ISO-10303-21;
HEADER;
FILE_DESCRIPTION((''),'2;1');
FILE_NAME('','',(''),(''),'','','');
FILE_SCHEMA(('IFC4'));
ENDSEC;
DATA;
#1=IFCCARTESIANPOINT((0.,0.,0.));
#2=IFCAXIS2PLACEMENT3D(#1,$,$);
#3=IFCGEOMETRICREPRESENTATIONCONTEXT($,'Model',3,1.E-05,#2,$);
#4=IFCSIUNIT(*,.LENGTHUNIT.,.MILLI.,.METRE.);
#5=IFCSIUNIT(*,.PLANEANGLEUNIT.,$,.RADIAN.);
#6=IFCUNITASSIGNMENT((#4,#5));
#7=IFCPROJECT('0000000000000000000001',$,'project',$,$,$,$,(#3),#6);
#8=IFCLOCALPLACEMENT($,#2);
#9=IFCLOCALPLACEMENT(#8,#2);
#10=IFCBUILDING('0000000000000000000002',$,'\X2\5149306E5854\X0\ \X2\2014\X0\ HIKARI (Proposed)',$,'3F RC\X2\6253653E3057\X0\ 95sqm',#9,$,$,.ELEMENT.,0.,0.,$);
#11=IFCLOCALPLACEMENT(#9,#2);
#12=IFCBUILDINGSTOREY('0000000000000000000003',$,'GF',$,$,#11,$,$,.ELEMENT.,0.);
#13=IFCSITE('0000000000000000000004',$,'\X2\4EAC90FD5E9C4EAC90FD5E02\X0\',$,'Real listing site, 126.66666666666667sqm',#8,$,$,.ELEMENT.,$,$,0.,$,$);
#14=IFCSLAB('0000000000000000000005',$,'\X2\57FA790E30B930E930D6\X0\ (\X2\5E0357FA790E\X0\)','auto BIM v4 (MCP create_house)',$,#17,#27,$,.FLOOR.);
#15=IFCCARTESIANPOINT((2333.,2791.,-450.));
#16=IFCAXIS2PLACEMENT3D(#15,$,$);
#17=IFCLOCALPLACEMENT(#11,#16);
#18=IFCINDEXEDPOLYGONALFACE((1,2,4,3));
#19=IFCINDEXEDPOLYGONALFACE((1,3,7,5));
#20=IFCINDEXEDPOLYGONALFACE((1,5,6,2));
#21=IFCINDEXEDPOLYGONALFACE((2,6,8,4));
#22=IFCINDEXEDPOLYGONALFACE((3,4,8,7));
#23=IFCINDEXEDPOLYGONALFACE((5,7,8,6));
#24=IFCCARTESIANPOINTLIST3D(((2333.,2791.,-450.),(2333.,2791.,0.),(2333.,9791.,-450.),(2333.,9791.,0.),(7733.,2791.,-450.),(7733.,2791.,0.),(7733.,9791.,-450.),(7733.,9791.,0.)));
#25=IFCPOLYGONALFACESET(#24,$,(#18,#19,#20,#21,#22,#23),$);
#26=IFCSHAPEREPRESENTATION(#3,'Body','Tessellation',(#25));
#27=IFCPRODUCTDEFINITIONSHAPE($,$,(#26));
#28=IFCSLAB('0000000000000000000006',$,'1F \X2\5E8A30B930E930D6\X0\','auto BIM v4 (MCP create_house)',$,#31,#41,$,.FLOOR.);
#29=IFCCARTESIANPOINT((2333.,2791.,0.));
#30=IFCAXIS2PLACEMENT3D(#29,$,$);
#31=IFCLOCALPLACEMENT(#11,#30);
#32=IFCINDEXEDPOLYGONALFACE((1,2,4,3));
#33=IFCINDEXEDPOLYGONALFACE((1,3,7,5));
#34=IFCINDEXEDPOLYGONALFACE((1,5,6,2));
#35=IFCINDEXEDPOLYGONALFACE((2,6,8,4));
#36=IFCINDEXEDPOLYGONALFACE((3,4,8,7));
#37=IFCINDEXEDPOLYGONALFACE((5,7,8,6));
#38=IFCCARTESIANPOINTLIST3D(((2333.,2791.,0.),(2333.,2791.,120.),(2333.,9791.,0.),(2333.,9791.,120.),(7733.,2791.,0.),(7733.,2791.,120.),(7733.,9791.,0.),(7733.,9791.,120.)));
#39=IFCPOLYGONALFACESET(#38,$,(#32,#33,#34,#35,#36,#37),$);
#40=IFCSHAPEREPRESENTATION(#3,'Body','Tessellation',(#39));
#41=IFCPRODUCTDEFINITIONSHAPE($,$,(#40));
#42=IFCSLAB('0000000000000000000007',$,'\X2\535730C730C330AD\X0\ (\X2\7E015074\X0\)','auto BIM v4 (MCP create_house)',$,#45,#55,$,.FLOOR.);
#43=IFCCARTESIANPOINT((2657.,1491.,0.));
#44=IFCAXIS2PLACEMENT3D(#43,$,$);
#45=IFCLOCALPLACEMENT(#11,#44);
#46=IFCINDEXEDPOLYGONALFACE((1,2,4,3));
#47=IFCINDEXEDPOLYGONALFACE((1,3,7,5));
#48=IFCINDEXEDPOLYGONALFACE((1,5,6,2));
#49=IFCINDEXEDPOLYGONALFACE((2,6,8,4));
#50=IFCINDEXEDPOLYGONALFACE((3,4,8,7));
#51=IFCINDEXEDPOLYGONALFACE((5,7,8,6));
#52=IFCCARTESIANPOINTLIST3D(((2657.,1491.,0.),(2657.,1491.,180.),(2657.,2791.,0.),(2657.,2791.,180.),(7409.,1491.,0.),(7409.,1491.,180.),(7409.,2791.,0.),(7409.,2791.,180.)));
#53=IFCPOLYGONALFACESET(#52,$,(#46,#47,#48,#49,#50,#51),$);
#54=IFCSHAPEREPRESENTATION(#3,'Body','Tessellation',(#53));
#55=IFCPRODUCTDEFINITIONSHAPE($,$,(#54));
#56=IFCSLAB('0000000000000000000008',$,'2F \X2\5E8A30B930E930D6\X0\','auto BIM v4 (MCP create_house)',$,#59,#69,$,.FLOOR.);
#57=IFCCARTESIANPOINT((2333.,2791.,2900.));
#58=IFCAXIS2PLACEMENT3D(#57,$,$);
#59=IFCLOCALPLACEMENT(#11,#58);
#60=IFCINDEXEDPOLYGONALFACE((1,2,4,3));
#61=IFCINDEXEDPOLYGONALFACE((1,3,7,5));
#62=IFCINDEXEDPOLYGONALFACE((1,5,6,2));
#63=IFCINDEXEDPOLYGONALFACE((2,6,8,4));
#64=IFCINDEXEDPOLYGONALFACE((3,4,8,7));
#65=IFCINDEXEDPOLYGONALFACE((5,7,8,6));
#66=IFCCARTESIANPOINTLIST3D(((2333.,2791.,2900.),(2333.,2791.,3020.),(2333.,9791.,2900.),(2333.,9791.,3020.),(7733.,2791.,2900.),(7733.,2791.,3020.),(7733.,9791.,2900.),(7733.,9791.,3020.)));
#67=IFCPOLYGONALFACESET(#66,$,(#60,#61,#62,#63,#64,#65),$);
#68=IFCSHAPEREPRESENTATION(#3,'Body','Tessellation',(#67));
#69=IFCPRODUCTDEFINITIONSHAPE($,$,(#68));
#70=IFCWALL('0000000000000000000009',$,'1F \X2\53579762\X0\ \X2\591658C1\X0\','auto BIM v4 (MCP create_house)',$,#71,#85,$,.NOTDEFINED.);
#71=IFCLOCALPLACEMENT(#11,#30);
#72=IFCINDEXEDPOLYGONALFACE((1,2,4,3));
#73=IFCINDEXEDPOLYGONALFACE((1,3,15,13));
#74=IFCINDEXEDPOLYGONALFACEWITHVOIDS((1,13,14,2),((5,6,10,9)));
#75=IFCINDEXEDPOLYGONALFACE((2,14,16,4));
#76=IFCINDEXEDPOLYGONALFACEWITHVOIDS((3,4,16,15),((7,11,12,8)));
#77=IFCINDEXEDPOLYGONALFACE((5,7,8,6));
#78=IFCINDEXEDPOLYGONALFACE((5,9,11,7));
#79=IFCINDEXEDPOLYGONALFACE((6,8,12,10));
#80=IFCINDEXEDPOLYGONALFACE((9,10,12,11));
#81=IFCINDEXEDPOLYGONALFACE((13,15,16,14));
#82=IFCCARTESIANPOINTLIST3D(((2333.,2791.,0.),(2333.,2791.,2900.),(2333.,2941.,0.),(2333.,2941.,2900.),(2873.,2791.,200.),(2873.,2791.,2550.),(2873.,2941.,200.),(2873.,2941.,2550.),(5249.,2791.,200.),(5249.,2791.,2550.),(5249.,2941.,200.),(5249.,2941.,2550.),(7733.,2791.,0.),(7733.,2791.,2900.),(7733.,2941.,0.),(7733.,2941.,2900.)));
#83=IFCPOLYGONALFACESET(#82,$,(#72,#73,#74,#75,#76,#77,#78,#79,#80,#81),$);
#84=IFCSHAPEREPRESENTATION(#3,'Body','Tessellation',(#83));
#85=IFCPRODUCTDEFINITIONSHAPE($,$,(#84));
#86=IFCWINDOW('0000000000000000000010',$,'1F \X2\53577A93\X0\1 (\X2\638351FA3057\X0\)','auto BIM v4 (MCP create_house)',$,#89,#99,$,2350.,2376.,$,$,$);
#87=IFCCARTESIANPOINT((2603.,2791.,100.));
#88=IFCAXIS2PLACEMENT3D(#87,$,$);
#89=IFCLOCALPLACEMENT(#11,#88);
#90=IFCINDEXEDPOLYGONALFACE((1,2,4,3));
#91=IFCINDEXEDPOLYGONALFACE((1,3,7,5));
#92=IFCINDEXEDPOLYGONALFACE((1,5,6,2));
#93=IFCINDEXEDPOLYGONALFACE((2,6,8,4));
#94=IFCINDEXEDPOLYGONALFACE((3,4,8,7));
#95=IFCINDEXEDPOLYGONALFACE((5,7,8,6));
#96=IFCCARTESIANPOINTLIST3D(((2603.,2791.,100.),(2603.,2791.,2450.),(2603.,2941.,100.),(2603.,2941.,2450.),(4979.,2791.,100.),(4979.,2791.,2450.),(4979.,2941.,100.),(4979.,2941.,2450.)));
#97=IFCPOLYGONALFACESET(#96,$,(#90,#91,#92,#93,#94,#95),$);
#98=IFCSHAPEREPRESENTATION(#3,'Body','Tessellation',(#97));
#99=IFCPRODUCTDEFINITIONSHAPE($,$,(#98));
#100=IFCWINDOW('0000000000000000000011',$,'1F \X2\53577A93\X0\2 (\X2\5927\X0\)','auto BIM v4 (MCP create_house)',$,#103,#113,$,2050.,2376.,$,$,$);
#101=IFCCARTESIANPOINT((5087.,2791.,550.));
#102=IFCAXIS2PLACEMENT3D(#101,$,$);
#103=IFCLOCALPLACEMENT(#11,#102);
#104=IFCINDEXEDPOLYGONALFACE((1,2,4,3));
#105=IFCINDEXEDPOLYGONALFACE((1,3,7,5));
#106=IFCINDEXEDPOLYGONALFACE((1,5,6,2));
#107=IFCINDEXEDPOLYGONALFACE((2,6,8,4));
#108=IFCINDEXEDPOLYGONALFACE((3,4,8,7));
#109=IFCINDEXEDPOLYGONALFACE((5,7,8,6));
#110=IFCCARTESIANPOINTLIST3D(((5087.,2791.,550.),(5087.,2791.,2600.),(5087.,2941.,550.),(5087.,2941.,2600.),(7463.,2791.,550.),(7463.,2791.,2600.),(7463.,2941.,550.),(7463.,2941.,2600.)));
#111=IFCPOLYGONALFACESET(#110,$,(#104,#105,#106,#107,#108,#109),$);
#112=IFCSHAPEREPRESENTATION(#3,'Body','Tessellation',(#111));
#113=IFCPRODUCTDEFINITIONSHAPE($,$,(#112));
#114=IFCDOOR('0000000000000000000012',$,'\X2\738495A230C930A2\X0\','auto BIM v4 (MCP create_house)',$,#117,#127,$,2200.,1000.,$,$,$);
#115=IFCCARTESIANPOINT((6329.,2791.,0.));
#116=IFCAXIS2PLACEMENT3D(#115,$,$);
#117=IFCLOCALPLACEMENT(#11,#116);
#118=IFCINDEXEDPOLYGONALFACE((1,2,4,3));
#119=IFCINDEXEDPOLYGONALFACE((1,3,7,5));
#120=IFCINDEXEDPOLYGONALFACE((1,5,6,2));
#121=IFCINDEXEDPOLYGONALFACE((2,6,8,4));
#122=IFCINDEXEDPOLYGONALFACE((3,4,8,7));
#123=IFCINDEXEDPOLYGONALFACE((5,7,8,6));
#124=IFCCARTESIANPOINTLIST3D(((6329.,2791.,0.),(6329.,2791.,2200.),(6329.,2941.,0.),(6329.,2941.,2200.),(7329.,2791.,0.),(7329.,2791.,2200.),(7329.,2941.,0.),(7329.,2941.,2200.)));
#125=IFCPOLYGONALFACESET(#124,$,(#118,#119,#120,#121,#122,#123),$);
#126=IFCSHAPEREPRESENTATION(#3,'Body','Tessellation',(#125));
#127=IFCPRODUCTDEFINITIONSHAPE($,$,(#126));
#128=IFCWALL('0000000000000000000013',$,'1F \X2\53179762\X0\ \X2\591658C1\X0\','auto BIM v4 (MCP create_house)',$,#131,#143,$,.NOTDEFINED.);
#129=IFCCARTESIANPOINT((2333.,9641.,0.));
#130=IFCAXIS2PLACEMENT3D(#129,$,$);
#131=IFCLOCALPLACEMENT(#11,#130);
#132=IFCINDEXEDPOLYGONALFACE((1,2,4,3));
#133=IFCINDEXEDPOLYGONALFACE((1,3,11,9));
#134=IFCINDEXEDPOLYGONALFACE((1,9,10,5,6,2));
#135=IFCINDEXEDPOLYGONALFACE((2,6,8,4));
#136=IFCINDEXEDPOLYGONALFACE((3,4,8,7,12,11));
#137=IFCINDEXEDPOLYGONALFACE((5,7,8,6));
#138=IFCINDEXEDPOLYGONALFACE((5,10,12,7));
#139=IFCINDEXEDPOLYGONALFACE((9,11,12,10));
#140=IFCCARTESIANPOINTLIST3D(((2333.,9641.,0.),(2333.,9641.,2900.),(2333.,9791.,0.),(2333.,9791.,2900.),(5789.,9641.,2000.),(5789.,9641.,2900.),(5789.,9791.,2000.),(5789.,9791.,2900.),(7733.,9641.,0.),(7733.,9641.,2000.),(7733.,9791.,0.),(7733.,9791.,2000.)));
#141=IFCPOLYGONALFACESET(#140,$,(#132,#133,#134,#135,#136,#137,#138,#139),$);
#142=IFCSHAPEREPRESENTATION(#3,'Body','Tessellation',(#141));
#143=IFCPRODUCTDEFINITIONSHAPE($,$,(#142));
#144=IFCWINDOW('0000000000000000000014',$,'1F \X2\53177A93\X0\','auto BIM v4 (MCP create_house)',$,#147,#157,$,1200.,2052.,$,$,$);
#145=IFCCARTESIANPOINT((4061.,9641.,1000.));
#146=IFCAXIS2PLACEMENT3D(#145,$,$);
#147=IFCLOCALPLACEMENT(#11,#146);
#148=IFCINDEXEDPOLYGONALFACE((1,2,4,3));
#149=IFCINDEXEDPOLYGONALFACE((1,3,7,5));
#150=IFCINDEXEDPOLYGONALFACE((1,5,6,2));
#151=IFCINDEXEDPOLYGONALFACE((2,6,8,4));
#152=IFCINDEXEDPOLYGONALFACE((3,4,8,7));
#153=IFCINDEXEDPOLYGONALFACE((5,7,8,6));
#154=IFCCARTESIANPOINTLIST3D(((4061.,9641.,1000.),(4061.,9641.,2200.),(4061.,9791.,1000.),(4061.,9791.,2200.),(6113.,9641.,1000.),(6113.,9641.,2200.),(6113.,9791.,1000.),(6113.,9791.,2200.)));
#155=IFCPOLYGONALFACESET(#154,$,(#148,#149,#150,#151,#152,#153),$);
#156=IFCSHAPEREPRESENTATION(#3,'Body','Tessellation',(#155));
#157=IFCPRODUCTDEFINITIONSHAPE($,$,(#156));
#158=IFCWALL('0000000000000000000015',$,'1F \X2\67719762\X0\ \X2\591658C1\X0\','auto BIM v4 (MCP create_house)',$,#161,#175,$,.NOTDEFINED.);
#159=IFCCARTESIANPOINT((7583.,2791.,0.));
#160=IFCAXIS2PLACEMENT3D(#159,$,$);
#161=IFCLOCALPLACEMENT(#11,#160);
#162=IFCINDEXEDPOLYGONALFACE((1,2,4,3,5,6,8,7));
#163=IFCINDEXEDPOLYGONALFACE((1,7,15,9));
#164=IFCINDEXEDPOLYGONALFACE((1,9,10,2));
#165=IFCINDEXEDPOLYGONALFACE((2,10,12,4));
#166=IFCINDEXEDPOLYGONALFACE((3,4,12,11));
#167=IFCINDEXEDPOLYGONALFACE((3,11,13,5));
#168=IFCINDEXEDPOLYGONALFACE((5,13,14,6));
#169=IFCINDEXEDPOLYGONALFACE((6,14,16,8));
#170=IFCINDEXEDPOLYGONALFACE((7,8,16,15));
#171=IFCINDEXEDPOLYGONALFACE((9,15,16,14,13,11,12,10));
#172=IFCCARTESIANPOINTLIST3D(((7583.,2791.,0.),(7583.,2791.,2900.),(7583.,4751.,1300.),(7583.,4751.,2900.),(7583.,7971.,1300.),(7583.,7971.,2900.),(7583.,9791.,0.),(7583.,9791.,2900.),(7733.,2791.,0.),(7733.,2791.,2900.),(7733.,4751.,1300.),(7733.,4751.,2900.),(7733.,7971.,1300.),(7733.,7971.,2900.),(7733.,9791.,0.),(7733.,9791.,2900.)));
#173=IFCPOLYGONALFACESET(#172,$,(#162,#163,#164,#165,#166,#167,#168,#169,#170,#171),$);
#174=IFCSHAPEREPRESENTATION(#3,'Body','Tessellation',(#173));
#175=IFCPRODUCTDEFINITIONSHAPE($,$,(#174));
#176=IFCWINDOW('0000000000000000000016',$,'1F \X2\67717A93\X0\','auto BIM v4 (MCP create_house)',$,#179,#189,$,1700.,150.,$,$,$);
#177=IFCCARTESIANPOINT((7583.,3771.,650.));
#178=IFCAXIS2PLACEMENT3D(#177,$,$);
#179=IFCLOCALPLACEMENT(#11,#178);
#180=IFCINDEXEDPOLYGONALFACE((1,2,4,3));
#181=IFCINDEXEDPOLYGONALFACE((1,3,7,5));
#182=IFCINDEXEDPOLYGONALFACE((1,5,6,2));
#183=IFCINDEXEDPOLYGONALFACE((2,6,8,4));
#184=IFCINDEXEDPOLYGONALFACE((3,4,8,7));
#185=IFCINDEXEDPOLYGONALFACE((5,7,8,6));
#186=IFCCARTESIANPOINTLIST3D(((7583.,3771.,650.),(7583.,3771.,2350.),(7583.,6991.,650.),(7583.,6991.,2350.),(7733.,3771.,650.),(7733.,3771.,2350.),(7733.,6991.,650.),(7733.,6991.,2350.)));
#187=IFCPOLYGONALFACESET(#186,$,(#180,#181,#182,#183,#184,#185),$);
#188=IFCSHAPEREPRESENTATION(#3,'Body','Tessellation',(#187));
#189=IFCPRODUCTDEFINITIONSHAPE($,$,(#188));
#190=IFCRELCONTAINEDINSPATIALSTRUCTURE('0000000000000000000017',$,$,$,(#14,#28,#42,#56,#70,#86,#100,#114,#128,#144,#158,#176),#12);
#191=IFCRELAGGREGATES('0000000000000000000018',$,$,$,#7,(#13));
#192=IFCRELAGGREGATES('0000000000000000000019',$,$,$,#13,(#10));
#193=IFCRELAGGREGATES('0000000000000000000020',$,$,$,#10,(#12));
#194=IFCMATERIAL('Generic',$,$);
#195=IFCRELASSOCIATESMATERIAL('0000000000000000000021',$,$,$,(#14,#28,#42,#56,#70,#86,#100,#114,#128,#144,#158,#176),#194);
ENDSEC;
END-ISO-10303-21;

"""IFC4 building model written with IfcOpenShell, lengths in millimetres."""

from ifc_helpers import new_model, si_unit, frame, frame_2d, origin, place, context, project, spatial, rectangle, extrude, material, element, fill, save


model = new_model("IFC4")

# Units and contexts
model_context = context("Model", 3, precision=1e-05, world=origin())
ifc_project = project(units=[si_unit("LENGTHUNIT", "METRE", prefix="MILLI"), si_unit("PLANEANGLEUNIT", "RADIAN")], contexts=[model_context])

# Site, building, storey
site_placement = place(None, origin())
site = spatial("IfcSite", under=ifc_project, at=site_placement, Name="京都府京都市", ObjectType="Real listing site, 126.66666666666667sqm", CompositionType="ELEMENT", RefElevation=0.0)
building_placement = place(site_placement, origin())
building = spatial("IfcBuilding", under=site, at=building_placement, Name="光の塔 — HIKARI (Proposed)", ObjectType="3F RC打放し 95sqm", CompositionType="ELEMENT", ElevationOfRefHeight=0.0, ElevationOfTerrain=0.0)
storey_placement = place(building_placement, origin())
storey = spatial("IfcBuildingStorey", under=building, at=storey_placement, Name="GF", CompositionType="ELEMENT", Elevation=0.0)

# Slabs
ifc_material = material(Name="Generic")
slab_1_placement = place(storey_placement, frame((2333.0, 2791.0, -450.0)))
element("IfcSlab", 1, at=slab_1_placement, inside=storey, material=ifc_material, Name="基礎スラブ (布基礎)", Description="auto BIM v4 (MCP create_house)", PredefinedType="FLOOR", context=model_context, shape_type="SweptSolid", body=[
    extrude(rectangle(XDim=5400.0, YDim=7000.0, at=frame_2d((2700.0, 3500.0))), frame((2333.0, 2791.0, -450.0)), (0.0, 0.0, 1.0), 450.0),
])
slab_2_placement = place(storey_placement, frame((2333.0, 2791.0, 0.0)))
element("IfcSlab", 2, at=slab_2_placement, inside=storey, material=ifc_material, Name="1F 床スラブ", Description="auto BIM v4 (MCP create_house)", PredefinedType="FLOOR", context=model_context, shape_type="SweptSolid", body=[
    extrude(rectangle(XDim=5400.0, YDim=7000.0, at=frame_2d((2700.0, 3500.0))), frame((2333.0, 2791.0, 0.0)), (0.0, 0.0, 1.0), 120.0),
])
slab_3_placement = place(storey_placement, frame((2657.0, 1491.0, 0.0)))
element("IfcSlab", 3, at=slab_3_placement, inside=storey, material=ifc_material, Name="南デッキ (縁側)", Description="auto BIM v4 (MCP create_house)", PredefinedType="FLOOR", context=model_context, shape_type="SweptSolid", body=[
    extrude(rectangle(XDim=4752.0, YDim=1300.0, at=frame_2d((2376.0, 650.0))), frame((2657.0, 1491.0, 0.0)), (0.0, 0.0, 1.0), 180.0),
])
slab_4_placement = place(storey_placement, frame((2333.0, 2791.0, 2900.0)))
element("IfcSlab", 4, at=slab_4_placement, inside=storey, material=ifc_material, Name="2F 床スラブ", Description="auto BIM v4 (MCP create_house)", PredefinedType="FLOOR", context=model_context, shape_type="SweptSolid", body=[
    extrude(rectangle(XDim=5400.0, YDim=7000.0, at=frame_2d((2700.0, 3500.0))), frame((2333.0, 2791.0, 2900.0)), (0.0, 0.0, 1.0), 120.0),
])

# Wall, openings, windows, door
wall_1_placement = place(storey_placement, frame((2333.0, 2791.0, 0.0)))
wall_1 = element("IfcWall", 5, at=wall_1_placement, inside=storey, material=ifc_material, Name="1F 南面 外壁", Description="auto BIM v4 (MCP create_house)", PredefinedType="NOTDEFINED", context=model_context, shape_type="SweptSolid", body=[
    extrude(rectangle(XDim=5400.0, YDim=150.0, at=frame_2d((2700.0, 75.0))), frame((2333.0, 2791.0, 0.0)), (0.0, 0.0, 1.0), 2900.0),
])
opening_1_placement = place(storey_placement, frame((2603.0, 2791.0, 100.0)))
opening_1 = element("IfcOpeningElement", 6, at=opening_1_placement, cuts=wall_1, PredefinedType="NOTDEFINED", context=model_context, shape_type="SweptSolid", body=[
    extrude(rectangle(XDim=2376.0, YDim=150.0, at=frame_2d((1188.0, 75.0))), frame((2603.0, 2791.0, 100.0)), (0.0, 0.0, 1.0), 2350.0),
])
opening_2_placement = place(storey_placement, frame((5087.0, 2791.0, 550.0)))
opening_2 = element("IfcOpeningElement", 7, at=opening_2_placement, cuts=wall_1, PredefinedType="NOTDEFINED", context=model_context, shape_type="SweptSolid", body=[
    extrude(rectangle(XDim=2376.0, YDim=150.0, at=frame_2d((1188.0, 75.0))), frame((5087.0, 2791.0, 550.0)), (0.0, 0.0, 1.0), 2050.0),
])
opening_3_placement = place(storey_placement, frame((6329.0, 2791.0, 0.0)))
opening_3 = element("IfcOpeningElement", 8, at=opening_3_placement, cuts=wall_1, PredefinedType="NOTDEFINED", context=model_context, shape_type="SweptSolid", body=[
    extrude(rectangle(XDim=1000.0, YDim=150.0, at=frame_2d((500.0, 75.0))), frame((6329.0, 2791.0, 0.0)), (0.0, 0.0, 1.0), 2200.0),
])
window_1_placement = place(storey_placement, frame((2603.0, 2791.0, 100.0)))
window_1 = element("IfcWindow", 9, at=window_1_placement, inside=storey, material=ifc_material, Name="1F 南窓1 (掃出し)", Description="auto BIM v4 (MCP create_house)", OverallHeight=2350.0, OverallWidth=2376.0, context=model_context, shape_type="SweptSolid", body=[
    extrude(rectangle(XDim=2376.0, YDim=150.0, at=frame_2d((1188.0, 75.0))), frame((2603.0, 2791.0, 100.0)), (0.0, 0.0, 1.0), 2350.0),
])
fill(opening_1, window_1)
window_2_placement = place(storey_placement, frame((5087.0, 2791.0, 550.0)))
window_2 = element("IfcWindow", 10, at=window_2_placement, inside=storey, material=ifc_material, Name="1F 南窓2 (大)", Description="auto BIM v4 (MCP create_house)", OverallHeight=2050.0, OverallWidth=2376.0, context=model_context, shape_type="SweptSolid", body=[
    extrude(rectangle(XDim=2376.0, YDim=150.0, at=frame_2d((1188.0, 75.0))), frame((5087.0, 2791.0, 550.0)), (0.0, 0.0, 1.0), 2050.0),
])
fill(opening_2, window_2)
door_placement = place(storey_placement, frame((6329.0, 2791.0, 0.0)))
door = element("IfcDoor", 11, at=door_placement, inside=storey, material=ifc_material, Name="玄関ドア", Description="auto BIM v4 (MCP create_house)", OverallHeight=2200.0, OverallWidth=1000.0, context=model_context, shape_type="SweptSolid", body=[
    extrude(rectangle(XDim=1000.0, YDim=150.0, at=frame_2d((500.0, 75.0))), frame((6329.0, 2791.0, 0.0)), (0.0, 0.0, 1.0), 2200.0),
])
fill(opening_3, door)

# Walls, openings, windows
wall_2_placement = place(storey_placement, frame((2333.0, 9641.0, 0.0)))
wall_2 = element("IfcWall", 12, at=wall_2_placement, inside=storey, material=ifc_material, Name="1F 北面 外壁", Description="auto BIM v4 (MCP create_house)", PredefinedType="NOTDEFINED", context=model_context, shape_type="SweptSolid", body=[
    extrude(rectangle(XDim=5400.0, YDim=150.0, at=frame_2d((2700.0, 75.0))), frame((2333.0, 9641.0, 0.0)), (0.0, 0.0, 1.0), 2900.0),
])
opening_4_placement = place(storey_placement, frame((4061.0, 9641.0, 1000.0)))
opening_4 = element("IfcOpeningElement", 13, at=opening_4_placement, cuts=wall_2, PredefinedType="NOTDEFINED", context=model_context, shape_type="SweptSolid", body=[
    extrude(rectangle(XDim=2052.0, YDim=150.0, at=frame_2d((1026.0, 75.0))), frame((4061.0, 9641.0, 1000.0)), (0.0, 0.0, 1.0), 1200.0),
])
window_3_placement = place(storey_placement, frame((4061.0, 9641.0, 1000.0)))
window_3 = element("IfcWindow", 14, at=window_3_placement, inside=storey, material=ifc_material, Name="1F 北窓", Description="auto BIM v4 (MCP create_house)", OverallHeight=1200.0, OverallWidth=2052.0, context=model_context, shape_type="SweptSolid", body=[
    extrude(rectangle(XDim=2052.0, YDim=150.0, at=frame_2d((1026.0, 75.0))), frame((4061.0, 9641.0, 1000.0)), (0.0, 0.0, 1.0), 1200.0),
])
fill(opening_4, window_3)
wall_3_placement = place(storey_placement, frame((7583.0, 2791.0, 0.0)))
wall_3 = element("IfcWall", 15, at=wall_3_placement, inside=storey, material=ifc_material, Name="1F 東面 外壁", Description="auto BIM v4 (MCP create_house)", PredefinedType="NOTDEFINED", context=model_context, shape_type="SweptSolid", body=[
    extrude(rectangle(XDim=150.0, YDim=7000.0, at=frame_2d((75.0, 3500.0))), frame((7583.0, 2791.0, 0.0)), (0.0, 0.0, 1.0), 2900.0),
])
opening_5_placement = place(storey_placement, frame((7583.0, 3771.0, 650.0)))
opening_5 = element("IfcOpeningElement", 16, at=opening_5_placement, cuts=wall_3, PredefinedType="NOTDEFINED", context=model_context, shape_type="SweptSolid", body=[
    extrude(rectangle(XDim=150.0, YDim=3220.0, at=frame_2d((75.0, 1610.0))), frame((7583.0, 3771.0, 650.0)), (0.0, 0.0, 1.0), 1700.0),
])
window_4_placement = place(storey_placement, frame((7583.0, 3771.0, 650.0)))
window_4 = element("IfcWindow", 17, at=window_4_placement, inside=storey, material=ifc_material, Name="1F 東窓", Description="auto BIM v4 (MCP create_house)", OverallHeight=1700.0, OverallWidth=150.0, context=model_context, shape_type="SweptSolid", body=[
    extrude(rectangle(XDim=150.0, YDim=3220.0, at=frame_2d((75.0, 1610.0))), frame((7583.0, 3771.0, 650.0)), (0.0, 0.0, 1.0), 1700.0),
])
fill(opening_5, window_4)

save(model, "model.ifc")
